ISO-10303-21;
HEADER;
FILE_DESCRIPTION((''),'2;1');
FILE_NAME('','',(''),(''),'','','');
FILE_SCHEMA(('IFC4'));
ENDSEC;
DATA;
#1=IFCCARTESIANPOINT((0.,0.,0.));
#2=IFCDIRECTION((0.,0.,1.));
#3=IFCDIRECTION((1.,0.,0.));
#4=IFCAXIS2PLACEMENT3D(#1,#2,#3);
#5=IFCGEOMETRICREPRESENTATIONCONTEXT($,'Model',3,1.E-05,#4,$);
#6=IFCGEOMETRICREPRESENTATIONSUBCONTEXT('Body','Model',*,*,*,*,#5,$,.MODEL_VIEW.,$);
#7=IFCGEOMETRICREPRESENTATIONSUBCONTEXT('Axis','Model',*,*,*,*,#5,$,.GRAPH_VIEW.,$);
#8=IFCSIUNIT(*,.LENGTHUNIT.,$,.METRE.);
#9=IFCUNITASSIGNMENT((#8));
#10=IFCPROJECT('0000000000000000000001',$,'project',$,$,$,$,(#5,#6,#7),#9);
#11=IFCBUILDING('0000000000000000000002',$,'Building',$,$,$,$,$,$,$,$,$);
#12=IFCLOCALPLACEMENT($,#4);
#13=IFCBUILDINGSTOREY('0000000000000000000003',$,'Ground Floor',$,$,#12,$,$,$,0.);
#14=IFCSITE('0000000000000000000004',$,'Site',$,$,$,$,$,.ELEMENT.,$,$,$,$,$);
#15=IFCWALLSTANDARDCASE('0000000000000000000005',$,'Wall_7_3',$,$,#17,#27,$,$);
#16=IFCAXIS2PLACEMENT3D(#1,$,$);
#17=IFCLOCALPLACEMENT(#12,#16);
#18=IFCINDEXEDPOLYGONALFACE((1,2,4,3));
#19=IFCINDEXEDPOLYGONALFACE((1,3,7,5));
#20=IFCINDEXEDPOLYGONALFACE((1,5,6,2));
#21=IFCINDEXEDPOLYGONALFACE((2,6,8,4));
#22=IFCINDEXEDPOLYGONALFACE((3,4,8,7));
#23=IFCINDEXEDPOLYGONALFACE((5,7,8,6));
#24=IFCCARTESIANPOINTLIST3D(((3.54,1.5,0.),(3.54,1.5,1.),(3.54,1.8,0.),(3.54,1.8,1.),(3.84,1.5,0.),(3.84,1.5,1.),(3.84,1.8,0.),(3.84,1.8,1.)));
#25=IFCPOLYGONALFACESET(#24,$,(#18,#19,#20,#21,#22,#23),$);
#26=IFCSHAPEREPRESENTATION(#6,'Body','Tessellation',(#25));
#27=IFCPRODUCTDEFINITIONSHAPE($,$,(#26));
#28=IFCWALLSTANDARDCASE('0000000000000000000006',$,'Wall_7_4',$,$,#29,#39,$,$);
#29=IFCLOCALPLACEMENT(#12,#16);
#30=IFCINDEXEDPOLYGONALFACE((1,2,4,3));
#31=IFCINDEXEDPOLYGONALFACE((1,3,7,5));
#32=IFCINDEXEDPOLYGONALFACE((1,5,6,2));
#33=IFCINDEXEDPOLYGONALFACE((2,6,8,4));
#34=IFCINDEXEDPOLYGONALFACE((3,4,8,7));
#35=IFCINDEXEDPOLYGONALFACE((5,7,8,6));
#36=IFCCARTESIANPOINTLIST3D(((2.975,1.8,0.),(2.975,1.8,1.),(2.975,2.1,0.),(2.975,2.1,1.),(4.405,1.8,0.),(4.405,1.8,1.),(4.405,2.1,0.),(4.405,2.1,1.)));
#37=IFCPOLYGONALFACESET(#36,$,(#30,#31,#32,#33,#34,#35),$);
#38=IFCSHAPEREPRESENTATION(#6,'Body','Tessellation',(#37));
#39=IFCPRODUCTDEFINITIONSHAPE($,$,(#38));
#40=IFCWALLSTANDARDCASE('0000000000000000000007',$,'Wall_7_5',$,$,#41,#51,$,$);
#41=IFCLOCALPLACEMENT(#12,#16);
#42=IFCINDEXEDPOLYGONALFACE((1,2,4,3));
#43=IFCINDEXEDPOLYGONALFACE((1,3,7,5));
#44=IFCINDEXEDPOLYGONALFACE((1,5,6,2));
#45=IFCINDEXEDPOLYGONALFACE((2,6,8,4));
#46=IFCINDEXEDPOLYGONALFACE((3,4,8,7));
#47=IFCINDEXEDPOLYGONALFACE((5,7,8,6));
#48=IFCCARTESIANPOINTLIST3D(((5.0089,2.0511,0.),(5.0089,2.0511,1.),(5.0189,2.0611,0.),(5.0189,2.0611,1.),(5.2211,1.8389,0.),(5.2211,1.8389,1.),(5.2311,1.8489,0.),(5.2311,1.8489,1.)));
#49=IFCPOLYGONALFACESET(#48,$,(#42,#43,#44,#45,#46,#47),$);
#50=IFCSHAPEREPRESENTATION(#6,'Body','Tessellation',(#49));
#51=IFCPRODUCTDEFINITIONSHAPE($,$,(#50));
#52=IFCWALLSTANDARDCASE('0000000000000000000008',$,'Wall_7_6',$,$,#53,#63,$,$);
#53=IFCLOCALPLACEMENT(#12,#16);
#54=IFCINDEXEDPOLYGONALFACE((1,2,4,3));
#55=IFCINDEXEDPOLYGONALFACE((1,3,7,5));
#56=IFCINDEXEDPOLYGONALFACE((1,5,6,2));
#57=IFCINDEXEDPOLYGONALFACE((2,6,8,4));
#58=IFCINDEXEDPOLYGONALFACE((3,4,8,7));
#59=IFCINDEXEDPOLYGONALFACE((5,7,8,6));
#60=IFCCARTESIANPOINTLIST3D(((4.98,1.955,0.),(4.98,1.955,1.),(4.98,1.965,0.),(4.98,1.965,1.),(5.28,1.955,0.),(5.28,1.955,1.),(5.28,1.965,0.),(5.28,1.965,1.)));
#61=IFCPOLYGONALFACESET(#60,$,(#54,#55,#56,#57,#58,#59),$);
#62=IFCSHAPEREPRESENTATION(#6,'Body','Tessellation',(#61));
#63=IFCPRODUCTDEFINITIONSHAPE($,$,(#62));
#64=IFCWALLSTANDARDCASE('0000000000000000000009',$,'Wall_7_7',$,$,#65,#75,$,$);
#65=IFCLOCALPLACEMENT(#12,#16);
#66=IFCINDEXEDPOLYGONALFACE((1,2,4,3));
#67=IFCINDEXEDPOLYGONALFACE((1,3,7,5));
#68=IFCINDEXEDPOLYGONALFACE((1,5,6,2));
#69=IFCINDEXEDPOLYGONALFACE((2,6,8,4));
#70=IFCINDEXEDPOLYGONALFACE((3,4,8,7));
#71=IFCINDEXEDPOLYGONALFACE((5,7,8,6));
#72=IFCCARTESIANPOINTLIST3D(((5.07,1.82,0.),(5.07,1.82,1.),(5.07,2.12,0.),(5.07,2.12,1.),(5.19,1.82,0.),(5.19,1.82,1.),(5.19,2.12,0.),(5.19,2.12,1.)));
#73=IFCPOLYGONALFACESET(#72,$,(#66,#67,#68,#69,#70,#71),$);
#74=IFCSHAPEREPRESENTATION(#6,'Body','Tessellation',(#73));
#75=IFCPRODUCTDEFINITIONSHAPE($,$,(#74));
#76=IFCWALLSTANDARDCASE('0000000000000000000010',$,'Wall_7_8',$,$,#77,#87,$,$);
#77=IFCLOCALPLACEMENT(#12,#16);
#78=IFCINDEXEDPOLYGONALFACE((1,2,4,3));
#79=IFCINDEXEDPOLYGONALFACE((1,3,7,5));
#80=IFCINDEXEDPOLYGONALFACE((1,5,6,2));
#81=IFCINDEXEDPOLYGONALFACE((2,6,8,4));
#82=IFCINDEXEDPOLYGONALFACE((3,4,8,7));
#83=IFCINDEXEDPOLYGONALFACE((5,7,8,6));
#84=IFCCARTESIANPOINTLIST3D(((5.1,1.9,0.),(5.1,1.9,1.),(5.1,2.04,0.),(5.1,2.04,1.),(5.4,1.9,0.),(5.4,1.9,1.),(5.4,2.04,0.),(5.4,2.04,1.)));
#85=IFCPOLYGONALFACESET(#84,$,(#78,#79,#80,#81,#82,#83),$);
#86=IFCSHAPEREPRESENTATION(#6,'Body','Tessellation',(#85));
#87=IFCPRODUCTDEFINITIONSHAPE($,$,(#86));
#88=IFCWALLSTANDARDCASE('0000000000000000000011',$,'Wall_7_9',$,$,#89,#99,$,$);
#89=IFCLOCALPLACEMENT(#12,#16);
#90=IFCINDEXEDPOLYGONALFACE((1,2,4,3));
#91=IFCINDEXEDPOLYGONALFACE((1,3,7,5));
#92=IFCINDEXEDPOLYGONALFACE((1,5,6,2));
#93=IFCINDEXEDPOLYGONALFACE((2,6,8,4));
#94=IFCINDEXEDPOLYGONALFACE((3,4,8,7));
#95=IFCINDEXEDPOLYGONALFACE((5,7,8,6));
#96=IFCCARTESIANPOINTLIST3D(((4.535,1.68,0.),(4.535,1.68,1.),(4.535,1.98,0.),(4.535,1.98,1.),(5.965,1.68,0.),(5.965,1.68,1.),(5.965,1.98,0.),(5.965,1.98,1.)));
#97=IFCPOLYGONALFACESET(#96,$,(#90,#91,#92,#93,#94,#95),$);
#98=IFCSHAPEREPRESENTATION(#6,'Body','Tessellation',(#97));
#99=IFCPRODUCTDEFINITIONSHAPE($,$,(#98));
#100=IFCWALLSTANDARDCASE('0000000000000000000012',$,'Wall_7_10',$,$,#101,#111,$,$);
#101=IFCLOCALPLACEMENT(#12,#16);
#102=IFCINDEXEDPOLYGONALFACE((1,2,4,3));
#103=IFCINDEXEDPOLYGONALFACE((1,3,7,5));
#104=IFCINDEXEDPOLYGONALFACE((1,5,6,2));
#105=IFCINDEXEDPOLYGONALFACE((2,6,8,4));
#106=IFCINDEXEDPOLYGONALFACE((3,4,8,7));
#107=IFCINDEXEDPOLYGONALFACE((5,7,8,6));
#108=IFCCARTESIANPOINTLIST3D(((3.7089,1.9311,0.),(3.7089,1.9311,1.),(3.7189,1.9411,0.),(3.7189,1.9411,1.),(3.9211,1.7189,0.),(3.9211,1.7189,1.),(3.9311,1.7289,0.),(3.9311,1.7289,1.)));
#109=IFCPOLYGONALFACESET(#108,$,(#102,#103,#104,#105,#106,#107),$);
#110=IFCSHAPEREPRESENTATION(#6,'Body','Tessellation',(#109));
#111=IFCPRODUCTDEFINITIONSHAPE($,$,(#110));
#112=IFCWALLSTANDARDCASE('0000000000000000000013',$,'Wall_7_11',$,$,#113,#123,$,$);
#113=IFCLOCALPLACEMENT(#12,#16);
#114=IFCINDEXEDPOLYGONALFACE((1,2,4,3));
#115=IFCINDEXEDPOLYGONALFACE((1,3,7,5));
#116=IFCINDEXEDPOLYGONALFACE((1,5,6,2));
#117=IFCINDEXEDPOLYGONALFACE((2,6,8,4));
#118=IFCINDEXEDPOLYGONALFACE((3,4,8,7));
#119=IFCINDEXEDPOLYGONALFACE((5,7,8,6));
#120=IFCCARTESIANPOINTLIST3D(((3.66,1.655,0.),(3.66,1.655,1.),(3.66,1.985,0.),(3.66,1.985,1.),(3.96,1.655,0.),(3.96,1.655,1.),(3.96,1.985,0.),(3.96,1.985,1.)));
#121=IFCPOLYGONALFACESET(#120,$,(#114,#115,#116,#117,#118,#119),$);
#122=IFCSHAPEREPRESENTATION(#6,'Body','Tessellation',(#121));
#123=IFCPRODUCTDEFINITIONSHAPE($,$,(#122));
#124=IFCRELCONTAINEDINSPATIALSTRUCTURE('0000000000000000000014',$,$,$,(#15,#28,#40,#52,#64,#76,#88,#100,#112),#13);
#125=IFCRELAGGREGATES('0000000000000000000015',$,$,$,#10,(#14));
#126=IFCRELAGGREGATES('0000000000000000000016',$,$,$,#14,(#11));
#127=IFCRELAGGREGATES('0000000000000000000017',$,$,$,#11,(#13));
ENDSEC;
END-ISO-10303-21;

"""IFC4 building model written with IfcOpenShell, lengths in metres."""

from ifc_helpers import new_model, si_unit, frame, origin_with_axes, origin_2d, place, context, subcontext, project, spatial, rectangle, extrude, element, save


model = new_model("IFC4")

# Units and contexts
model_context = context("Model", 3, precision=1e-05, world=origin_with_axes())
body_context = subcontext(model_context, "Body", "Model", "MODEL_VIEW")
axis_context = subcontext(model_context, "Axis", "Model", "GRAPH_VIEW")
ifc_project = project(units=[si_unit("LENGTHUNIT", "METRE")], contexts=[model_context, body_context, axis_context])

# Site, building, storey
site = spatial("IfcSite", under=ifc_project, Name="Site", CompositionType="ELEMENT")
building = spatial("IfcBuilding", under=site, Name="Building")
storey_placement = place(None, origin_with_axes())
storey = spatial("IfcBuildingStorey", under=building, at=storey_placement, Name="Ground Floor", Elevation=0.0)

# Walls
wall_1_placement = place(storey_placement, frame((3.69, 1.65, 0.0), z_axis=(0.0, 0.0, 1.0), x_axis=(0.0, 1.0, 0.0)))
element("IfcWallStandardCase", 1, at=wall_1_placement, inside=storey, Name="Wall_7_3", context=body_context, shape_type="SweptSolid", body=[
    extrude(rectangle(XDim=0.3, YDim=0.3, at=origin_2d()), origin_with_axes(), (0.0, 0.0, 1.0), 1.0),
])
wall_2_placement = place(storey_placement, frame((3.69, 1.95, 0.0), z_axis=(0.0, 0.0, 1.0), x_axis=(1.0, 0.0, 0.0)))
element("IfcWallStandardCase", 2, at=wall_2_placement, inside=storey, Name="Wall_7_4", context=body_context, shape_type="SweptSolid", body=[
    extrude(rectangle(XDim=1.43, YDim=0.3, at=origin_2d()), origin_with_axes(), (0.0, 0.0, 1.0), 1.0),
])
wall_3_placement = place(storey_placement, frame((5.12, 1.95, 0.0), z_axis=(0.0, 0.0, 1.0), x_axis=(0.707107, 0.707107, 0.0)))
element("IfcWallStandardCase", 3, at=wall_3_placement, inside=storey, Name="Wall_7_5", context=body_context, shape_type="SweptSolid", body=[
    extrude(rectangle(XDim=0.0141, YDim=0.3, at=origin_2d()), origin_with_axes(), (0.0, 0.0, 1.0), 1.0),
])
wall_4_placement = place(storey_placement, frame((5.13, 1.96, 0.0), z_axis=(0.0, 0.0, 1.0), x_axis=(0.0, 1.0, 0.0)))
element("IfcWallStandardCase", 4, at=wall_4_placement, inside=storey, Name="Wall_7_6", context=body_context, shape_type="SweptSolid", body=[
    extrude(rectangle(XDim=0.01, YDim=0.3, at=origin_2d()), origin_with_axes(), (0.0, 0.0, 1.0), 1.0),
])
wall_5_placement = place(storey_placement, frame((5.13, 1.97, 0.0), z_axis=(0.0, 0.0, 1.0), x_axis=(1.0, 0.0, 0.0)))
element("IfcWallStandardCase", 5, at=wall_5_placement, inside=storey, Name="Wall_7_7", context=body_context, shape_type="SweptSolid", body=[
    extrude(rectangle(XDim=0.12, YDim=0.3, at=origin_2d()), origin_with_axes(), (0.0, 0.0, 1.0), 1.0),
])
wall_6_placement = place(storey_placement, frame((5.25, 1.97, 0.0), z_axis=(0.0, 0.0, 1.0), x_axis=(0.0, -1.0, 0.0)))
element("IfcWallStandardCase", 6, at=wall_6_placement, inside=storey, Name="Wall_7_8", context=body_context, shape_type="SweptSolid", body=[
    extrude(rectangle(XDim=0.14, YDim=0.3, at=origin_2d()), origin_with_axes(), (0.0, 0.0, 1.0), 1.0),
])
wall_7_placement = place(storey_placement, frame((5.25, 1.83, 0.0), z_axis=(0.0, 0.0, 1.0), x_axis=(-1.0, 0.0, 0.0)))
element("IfcWallStandardCase", 7, at=wall_7_placement, inside=storey, Name="Wall_7_9", context=body_context, shape_type="SweptSolid", body=[
    extrude(rectangle(XDim=1.43, YDim=0.3, at=origin_2d()), origin_with_axes(), (0.0, 0.0, 1.0), 1.0),
])
wall_8_placement = place(storey_placement, frame((3.82, 1.83, 0.0), z_axis=(0.0, 0.0, 1.0), x_axis=(-0.707107, -0.707107, 0.0)))
element("IfcWallStandardCase", 8, at=wall_8_placement, inside=storey, Name="Wall_7_10", context=body_context, shape_type="SweptSolid", body=[
    extrude(rectangle(XDim=0.0141, YDim=0.3, at=origin_2d()), origin_with_axes(), (0.0, 0.0, 1.0), 1.0),
])
wall_9_placement = place(storey_placement, frame((3.81, 1.82, 0.0), z_axis=(0.0, 0.0, 1.0), x_axis=(0.0, -1.0, 0.0)))
element("IfcWallStandardCase", 9, at=wall_9_placement, inside=storey, Name="Wall_7_11", context=body_context, shape_type="SweptSolid", body=[
    extrude(rectangle(XDim=0.33, YDim=0.3, at=origin_2d()), origin_with_axes(), (0.0, 0.0, 1.0), 1.0),
])

save(model, "model.ifc")
